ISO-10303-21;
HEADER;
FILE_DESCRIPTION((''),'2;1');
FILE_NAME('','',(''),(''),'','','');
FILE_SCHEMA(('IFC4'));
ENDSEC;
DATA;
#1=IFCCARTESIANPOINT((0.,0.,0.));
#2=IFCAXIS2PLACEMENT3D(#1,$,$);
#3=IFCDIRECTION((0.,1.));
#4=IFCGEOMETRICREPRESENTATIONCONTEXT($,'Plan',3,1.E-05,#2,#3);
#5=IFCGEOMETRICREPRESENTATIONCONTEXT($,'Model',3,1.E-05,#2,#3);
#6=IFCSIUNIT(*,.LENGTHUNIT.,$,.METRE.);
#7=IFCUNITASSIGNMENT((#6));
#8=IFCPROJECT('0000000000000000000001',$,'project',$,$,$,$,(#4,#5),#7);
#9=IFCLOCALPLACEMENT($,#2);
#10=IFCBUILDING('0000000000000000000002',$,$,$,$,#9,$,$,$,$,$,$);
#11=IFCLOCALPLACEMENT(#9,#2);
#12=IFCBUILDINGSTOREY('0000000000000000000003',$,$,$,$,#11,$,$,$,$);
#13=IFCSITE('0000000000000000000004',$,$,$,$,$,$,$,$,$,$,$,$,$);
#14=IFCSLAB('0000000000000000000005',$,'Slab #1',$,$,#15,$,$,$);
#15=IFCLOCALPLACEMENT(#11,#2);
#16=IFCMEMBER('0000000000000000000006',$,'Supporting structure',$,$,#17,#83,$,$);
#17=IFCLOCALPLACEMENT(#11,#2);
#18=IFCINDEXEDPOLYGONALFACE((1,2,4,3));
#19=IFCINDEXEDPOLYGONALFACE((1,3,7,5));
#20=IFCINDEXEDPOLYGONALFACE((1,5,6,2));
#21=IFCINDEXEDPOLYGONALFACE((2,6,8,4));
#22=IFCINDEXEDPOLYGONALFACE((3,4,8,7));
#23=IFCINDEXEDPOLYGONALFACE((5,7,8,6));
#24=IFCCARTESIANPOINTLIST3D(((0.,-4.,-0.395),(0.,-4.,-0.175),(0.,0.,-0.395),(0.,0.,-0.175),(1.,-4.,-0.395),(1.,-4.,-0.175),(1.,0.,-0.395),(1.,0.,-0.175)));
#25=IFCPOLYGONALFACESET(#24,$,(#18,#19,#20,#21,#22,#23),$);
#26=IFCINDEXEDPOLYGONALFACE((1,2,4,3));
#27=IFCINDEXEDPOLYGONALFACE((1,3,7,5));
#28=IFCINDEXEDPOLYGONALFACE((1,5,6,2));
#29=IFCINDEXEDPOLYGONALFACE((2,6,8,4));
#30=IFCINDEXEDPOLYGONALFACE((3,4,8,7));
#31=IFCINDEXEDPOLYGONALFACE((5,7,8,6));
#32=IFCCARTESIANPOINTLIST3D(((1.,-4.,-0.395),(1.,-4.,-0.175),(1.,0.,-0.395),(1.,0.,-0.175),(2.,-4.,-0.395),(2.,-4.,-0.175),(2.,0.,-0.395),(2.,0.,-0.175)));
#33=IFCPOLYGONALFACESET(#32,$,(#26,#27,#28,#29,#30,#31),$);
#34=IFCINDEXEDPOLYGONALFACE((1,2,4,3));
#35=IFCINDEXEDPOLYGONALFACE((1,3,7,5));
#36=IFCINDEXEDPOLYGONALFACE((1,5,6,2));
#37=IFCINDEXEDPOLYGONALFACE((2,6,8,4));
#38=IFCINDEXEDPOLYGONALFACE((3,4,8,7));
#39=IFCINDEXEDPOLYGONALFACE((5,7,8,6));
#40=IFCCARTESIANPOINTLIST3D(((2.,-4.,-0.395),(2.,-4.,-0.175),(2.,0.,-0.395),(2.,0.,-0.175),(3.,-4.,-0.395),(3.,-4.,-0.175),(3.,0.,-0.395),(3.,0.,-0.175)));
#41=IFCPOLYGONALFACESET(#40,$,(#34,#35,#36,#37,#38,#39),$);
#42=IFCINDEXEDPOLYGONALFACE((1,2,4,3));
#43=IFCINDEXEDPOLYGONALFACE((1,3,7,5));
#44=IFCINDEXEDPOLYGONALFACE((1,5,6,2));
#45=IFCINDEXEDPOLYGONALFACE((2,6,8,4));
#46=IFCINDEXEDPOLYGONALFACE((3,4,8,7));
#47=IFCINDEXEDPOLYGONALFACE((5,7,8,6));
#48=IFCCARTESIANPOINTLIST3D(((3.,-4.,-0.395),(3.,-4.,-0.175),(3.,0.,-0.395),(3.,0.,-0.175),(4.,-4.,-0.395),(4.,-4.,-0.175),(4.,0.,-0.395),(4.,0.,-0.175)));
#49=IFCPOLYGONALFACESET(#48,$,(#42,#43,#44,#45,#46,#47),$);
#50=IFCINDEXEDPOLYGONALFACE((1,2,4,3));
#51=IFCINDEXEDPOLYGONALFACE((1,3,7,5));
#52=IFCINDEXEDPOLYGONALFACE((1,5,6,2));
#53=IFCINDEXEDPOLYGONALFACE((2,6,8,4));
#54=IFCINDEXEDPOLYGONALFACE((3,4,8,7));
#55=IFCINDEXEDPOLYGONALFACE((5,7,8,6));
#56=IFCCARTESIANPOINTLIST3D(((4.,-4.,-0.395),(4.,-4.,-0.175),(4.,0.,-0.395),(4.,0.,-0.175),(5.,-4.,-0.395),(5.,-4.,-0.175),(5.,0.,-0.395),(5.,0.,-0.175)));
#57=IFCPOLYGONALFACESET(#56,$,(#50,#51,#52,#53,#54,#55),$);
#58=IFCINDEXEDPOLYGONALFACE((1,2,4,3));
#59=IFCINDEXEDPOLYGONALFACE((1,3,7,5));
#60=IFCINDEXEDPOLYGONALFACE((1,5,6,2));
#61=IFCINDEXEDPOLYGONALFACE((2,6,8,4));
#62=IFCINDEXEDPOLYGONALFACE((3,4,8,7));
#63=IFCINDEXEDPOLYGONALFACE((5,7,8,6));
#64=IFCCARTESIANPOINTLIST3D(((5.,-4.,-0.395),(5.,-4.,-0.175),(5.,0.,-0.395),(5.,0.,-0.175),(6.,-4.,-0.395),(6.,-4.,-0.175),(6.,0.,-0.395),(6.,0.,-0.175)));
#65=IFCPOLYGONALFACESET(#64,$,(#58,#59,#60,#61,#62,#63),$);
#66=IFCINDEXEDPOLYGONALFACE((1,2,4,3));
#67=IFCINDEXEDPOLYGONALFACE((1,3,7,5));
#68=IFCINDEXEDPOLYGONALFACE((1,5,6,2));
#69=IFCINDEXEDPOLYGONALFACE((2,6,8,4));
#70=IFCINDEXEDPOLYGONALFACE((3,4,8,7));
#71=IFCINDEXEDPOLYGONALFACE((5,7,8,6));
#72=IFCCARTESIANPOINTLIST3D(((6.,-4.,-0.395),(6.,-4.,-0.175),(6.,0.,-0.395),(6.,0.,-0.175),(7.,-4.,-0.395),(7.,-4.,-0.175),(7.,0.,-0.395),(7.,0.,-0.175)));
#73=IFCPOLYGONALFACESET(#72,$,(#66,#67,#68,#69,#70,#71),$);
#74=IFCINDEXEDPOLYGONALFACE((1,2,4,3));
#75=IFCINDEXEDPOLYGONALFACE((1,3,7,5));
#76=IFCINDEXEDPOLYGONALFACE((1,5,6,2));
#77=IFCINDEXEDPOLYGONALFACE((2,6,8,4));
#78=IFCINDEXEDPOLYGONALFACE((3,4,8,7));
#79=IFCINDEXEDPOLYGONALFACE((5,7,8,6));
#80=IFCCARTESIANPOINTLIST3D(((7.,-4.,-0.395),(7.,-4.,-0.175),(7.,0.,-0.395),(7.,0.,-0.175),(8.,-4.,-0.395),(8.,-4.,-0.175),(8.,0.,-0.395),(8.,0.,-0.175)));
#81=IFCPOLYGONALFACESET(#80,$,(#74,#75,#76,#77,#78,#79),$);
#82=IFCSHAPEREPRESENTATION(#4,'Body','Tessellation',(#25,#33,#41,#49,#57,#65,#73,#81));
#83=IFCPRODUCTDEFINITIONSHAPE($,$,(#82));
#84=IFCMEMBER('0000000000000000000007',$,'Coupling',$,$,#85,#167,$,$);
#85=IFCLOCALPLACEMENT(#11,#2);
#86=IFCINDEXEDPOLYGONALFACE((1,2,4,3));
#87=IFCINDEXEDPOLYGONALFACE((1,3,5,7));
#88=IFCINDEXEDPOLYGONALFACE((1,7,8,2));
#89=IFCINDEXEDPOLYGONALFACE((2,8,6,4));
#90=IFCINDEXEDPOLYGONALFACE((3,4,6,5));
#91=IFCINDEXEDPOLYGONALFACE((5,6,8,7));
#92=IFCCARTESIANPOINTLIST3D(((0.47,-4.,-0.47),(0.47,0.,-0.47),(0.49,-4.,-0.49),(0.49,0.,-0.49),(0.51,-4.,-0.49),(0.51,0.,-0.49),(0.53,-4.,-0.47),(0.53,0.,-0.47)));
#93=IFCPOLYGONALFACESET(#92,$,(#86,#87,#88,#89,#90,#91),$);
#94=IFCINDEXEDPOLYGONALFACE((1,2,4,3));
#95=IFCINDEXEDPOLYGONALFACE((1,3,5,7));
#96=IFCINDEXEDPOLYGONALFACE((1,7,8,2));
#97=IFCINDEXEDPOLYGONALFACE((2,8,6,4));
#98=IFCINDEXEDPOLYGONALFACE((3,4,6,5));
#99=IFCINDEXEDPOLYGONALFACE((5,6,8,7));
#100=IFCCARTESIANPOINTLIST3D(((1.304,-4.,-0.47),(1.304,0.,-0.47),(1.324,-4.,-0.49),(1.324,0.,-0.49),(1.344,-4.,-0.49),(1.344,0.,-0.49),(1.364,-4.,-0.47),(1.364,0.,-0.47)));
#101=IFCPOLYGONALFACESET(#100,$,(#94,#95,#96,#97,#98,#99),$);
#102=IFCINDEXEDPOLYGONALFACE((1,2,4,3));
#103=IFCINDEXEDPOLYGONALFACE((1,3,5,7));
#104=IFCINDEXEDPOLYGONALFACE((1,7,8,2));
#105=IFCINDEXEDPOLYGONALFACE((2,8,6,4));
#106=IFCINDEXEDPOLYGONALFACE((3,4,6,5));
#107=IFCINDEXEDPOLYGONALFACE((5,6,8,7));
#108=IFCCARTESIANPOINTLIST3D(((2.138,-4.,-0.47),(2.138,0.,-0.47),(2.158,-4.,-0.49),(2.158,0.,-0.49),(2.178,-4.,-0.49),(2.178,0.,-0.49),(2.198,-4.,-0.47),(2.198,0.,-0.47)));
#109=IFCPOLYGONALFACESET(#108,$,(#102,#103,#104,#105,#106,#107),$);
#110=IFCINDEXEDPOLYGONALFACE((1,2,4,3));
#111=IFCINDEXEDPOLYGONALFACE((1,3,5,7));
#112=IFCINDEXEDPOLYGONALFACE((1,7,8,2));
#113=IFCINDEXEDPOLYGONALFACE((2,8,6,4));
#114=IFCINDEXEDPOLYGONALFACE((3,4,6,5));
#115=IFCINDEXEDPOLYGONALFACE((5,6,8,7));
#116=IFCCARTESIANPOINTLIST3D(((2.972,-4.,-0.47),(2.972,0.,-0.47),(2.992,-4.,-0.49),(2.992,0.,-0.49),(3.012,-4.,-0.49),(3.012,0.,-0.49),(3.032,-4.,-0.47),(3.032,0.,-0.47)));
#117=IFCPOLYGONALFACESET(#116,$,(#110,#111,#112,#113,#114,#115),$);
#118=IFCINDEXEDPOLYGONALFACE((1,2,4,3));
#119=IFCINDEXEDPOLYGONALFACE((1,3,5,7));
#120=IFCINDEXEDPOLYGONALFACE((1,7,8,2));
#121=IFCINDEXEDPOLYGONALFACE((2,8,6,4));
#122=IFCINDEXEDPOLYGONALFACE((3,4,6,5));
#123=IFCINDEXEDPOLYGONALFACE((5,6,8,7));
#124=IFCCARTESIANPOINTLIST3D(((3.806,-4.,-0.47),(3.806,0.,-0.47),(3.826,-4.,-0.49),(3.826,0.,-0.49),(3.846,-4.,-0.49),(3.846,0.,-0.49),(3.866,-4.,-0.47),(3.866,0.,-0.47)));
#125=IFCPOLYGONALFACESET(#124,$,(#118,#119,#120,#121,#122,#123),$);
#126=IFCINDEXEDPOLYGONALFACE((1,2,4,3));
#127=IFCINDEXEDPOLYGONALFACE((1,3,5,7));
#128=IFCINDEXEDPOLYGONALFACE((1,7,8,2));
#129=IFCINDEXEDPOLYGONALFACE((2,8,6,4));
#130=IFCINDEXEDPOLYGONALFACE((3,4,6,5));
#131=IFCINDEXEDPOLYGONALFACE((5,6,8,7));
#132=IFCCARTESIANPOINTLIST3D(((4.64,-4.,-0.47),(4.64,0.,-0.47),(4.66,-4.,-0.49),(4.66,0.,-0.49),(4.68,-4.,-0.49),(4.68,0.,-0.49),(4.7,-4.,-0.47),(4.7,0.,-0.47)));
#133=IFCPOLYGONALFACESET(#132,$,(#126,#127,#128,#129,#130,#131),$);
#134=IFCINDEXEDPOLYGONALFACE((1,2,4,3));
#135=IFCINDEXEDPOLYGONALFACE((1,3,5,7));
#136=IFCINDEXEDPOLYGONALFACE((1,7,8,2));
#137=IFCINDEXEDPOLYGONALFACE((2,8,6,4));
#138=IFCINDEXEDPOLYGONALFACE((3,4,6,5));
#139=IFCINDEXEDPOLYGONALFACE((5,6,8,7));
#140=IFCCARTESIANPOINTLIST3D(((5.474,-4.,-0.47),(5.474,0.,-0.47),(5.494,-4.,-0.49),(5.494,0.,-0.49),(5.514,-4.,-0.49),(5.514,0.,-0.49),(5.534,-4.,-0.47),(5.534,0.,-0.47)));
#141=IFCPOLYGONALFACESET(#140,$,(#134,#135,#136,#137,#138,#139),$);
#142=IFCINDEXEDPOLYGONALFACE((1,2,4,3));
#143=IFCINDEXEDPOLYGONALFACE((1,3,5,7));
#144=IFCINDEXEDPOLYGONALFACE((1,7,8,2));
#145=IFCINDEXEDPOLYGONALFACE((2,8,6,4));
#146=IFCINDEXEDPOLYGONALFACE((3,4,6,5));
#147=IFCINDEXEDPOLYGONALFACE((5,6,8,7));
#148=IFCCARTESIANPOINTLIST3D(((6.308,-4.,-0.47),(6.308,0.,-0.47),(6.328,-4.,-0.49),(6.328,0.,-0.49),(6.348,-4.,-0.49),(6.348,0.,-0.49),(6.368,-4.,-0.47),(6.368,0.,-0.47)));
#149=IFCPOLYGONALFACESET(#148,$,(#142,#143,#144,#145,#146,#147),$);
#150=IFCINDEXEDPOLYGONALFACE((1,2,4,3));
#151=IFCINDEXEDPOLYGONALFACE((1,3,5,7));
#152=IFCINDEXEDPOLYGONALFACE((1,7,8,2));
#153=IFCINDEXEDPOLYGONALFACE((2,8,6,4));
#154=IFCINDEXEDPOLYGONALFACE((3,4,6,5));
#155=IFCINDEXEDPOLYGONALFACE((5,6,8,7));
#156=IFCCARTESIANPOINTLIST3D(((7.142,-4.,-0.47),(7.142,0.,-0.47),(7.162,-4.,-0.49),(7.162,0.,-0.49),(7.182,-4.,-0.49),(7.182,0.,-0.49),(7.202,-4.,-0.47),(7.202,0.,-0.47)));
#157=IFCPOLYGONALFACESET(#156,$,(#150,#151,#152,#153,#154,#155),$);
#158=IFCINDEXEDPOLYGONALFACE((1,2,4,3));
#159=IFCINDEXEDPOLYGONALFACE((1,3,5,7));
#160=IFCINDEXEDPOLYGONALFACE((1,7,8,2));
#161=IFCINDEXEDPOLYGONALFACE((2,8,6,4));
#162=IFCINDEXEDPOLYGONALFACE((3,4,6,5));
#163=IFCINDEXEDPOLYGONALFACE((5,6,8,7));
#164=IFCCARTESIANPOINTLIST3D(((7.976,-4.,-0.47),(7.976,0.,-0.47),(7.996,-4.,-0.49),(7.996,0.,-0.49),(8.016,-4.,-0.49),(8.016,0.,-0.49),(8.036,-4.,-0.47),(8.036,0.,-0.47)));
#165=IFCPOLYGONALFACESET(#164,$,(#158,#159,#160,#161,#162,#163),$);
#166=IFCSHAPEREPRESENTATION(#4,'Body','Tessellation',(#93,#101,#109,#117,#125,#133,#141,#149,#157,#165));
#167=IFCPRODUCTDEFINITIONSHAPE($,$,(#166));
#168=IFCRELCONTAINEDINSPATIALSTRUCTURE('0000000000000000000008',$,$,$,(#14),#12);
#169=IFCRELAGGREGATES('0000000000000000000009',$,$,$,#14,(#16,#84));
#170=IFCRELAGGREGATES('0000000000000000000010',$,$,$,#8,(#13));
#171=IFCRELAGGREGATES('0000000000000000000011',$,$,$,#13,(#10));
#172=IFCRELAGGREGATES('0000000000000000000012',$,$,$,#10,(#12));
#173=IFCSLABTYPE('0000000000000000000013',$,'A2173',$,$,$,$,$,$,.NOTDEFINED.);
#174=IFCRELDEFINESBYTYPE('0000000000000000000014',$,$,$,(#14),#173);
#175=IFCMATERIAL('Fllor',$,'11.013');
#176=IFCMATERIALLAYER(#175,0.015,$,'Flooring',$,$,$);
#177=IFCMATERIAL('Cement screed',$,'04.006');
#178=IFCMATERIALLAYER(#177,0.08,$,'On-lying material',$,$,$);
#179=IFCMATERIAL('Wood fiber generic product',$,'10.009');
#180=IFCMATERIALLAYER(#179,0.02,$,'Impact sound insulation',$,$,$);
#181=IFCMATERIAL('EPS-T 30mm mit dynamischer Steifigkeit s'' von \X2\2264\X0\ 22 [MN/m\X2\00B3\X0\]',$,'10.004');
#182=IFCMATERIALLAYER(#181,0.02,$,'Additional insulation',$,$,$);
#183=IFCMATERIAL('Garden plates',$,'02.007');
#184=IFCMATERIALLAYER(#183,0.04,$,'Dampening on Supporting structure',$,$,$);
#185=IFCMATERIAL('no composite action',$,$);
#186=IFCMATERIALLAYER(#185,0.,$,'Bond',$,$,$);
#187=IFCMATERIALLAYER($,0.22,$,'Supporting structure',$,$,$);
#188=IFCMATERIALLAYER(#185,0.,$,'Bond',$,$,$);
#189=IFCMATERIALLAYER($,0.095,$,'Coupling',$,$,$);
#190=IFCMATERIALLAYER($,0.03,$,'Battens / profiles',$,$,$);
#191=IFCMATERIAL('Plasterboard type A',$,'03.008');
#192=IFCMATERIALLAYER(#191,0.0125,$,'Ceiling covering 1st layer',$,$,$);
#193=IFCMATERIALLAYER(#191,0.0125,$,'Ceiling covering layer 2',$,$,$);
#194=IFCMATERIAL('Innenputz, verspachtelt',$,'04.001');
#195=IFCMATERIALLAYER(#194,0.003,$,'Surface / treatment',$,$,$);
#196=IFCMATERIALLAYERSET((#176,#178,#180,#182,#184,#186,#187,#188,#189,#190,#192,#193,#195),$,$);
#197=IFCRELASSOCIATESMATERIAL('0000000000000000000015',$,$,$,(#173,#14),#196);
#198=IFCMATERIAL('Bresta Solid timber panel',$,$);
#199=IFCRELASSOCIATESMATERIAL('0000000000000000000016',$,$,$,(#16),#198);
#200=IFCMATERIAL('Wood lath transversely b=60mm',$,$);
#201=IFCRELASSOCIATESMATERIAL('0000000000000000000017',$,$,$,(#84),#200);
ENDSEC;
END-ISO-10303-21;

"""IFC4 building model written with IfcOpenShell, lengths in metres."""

from ifc_helpers import new_model, si_unit, direction, frame, frame_2d, origin, place, context, project, spatial, polyline, rectangle, outline, extrude, material, layer, layer_set, type_object, element, aggregate, save


model = new_model("IFC4")

# Units and contexts
plan_context = context("Plan", 3, precision=1e-05, world=origin(), true_north=direction((0.0, 1.0)))
model_context = context("Model", 3, precision=1e-05, world=origin(), true_north=direction((0.0, 1.0)))
ifc_project = project(units=[si_unit("LENGTHUNIT", "METRE")], contexts=[plan_context, model_context])

# Site, building, storey
site = spatial("IfcSite", under=ifc_project)
building_placement = place(None, origin())
building = spatial("IfcBuilding", under=site, at=building_placement)
storey_placement = place(building_placement, origin())
storey = spatial("IfcBuildingStorey", under=building, at=storey_placement)

# Slab, members
ifc_material_1 = material(Name="Fllor", Category="11.013")
ifc_layer_1 = layer(ifc_material_1, 0.015, Name="Flooring")
ifc_material_2 = material(Name="Cement screed", Category="04.006")
ifc_layer_2 = layer(ifc_material_2, 0.08, Name="On-lying material")
ifc_material_3 = material(Name="Wood fiber generic product", Category="10.009")
ifc_layer_3 = layer(ifc_material_3, 0.02, Name="Impact sound insulation")
ifc_material_4 = material(Name="EPS-T 30mm mit dynamischer Steifigkeit s' von ≤ 22 [MN/m³]", Category="10.004")
ifc_layer_4 = layer(ifc_material_4, 0.02, Name="Additional insulation")
ifc_material_5 = material(Name="Garden plates", Category="02.007")
ifc_layer_5 = layer(ifc_material_5, 0.04, Name="Dampening on Supporting structure")
ifc_material_6 = material(Name="no composite action")
ifc_layer_6 = layer(ifc_material_6, 0.0, Name="Bond")
ifc_layer_7 = layer(None, 0.22, Name="Supporting structure")
ifc_layer_8 = layer(ifc_material_6, 0.0, Name="Bond")
ifc_layer_9 = layer(None, 0.095, Name="Coupling")
ifc_layer_10 = layer(None, 0.03, Name="Battens / profiles")
ifc_material_7 = material(Name="Plasterboard type A", Category="03.008")
ifc_layer_11 = layer(ifc_material_7, 0.0125, Name="Ceiling covering 1st layer")
ifc_layer_12 = layer(ifc_material_7, 0.0125, Name="Ceiling covering layer 2")
ifc_material_8 = material(Name="Innenputz, verspachtelt", Category="04.001")
ifc_layer_13 = layer(ifc_material_8, 0.003, Name="Surface / treatment")
ifc_layer_set = layer_set([ifc_layer_1, ifc_layer_2, ifc_layer_3, ifc_layer_4, ifc_layer_5, ifc_layer_6, ifc_layer_7, ifc_layer_8, ifc_layer_9, ifc_layer_10, ifc_layer_11, ifc_layer_12, ifc_layer_13])
slab_type = type_object("IfcSlabType", Name="A2173", PredefinedType="NOTDEFINED", material=ifc_layer_set)
slab_placement = place(None, frame((0.0, 0.0, 0.0), z_axis=(0.0, 0.0, -1.0), x_axis=(1.0, 0.0, 0.0)))
slab = element("IfcSlab", 1, at=slab_placement, inside=storey, type_object=slab_type, material=ifc_layer_set, Name="Slab #1")
ifc_material_9 = material(Name="Bresta Solid timber panel")
member_1_placement = place(slab_placement, origin())
member_1 = element("IfcMember", 2, at=member_1_placement, material=ifc_material_9, Name="Supporting structure", context=plan_context, shape_type="SweptSolid", body=[
    extrude(rectangle(XDim=1.0, YDim=0.22, at=frame_2d((0.5, 0.11), x_axis=(1.0, 0.0))), frame((0.0, 4.0, 0.175), z_axis=(0.0, -1.0, 0.0), x_axis=(1.0, 0.0, 0.0)), (0.0, 0.0, 1.0), 4.0),
    extrude(rectangle(XDim=1.0, YDim=0.22, at=frame_2d((0.5, 0.11), x_axis=(1.0, 0.0))), frame((1.0, 4.0, 0.175), z_axis=(0.0, -1.0, 0.0), x_axis=(1.0, 0.0, 0.0)), (0.0, 0.0, 1.0), 4.0),
    extrude(rectangle(XDim=1.0, YDim=0.22, at=frame_2d((0.5, 0.11), x_axis=(1.0, 0.0))), frame((2.0, 4.0, 0.175), z_axis=(0.0, -1.0, 0.0), x_axis=(1.0, 0.0, 0.0)), (0.0, 0.0, 1.0), 4.0),
    extrude(rectangle(XDim=1.0, YDim=0.22, at=frame_2d((0.5, 0.11), x_axis=(1.0, 0.0))), frame((3.0, 4.0, 0.175), z_axis=(0.0, -1.0, 0.0), x_axis=(1.0, 0.0, 0.0)), (0.0, 0.0, 1.0), 4.0),
    extrude(rectangle(XDim=1.0, YDim=0.22, at=frame_2d((0.5, 0.11), x_axis=(1.0, 0.0))), frame((4.0, 4.0, 0.175), z_axis=(0.0, -1.0, 0.0), x_axis=(1.0, 0.0, 0.0)), (0.0, 0.0, 1.0), 4.0),
    extrude(rectangle(XDim=1.0, YDim=0.22, at=frame_2d((0.5, 0.11), x_axis=(1.0, 0.0))), frame((5.0, 4.0, 0.175), z_axis=(0.0, -1.0, 0.0), x_axis=(1.0, 0.0, 0.0)), (0.0, 0.0, 1.0), 4.0),
    extrude(rectangle(XDim=1.0, YDim=0.22, at=frame_2d((0.5, 0.11), x_axis=(1.0, 0.0))), frame((6.0, 4.0, 0.175), z_axis=(0.0, -1.0, 0.0), x_axis=(1.0, 0.0, 0.0)), (0.0, 0.0, 1.0), 4.0),
    extrude(rectangle(XDim=1.0, YDim=0.22, at=frame_2d((0.5, 0.11), x_axis=(1.0, 0.0))), frame((7.0, 4.0, 0.175), z_axis=(0.0, -1.0, 0.0), x_axis=(1.0, 0.0, 0.0)), (0.0, 0.0, 1.0), 4.0),
])
ifc_material_10 = material(Name="Wood lath transversely b=60mm")
member_2_placement = place(slab_placement, origin())
member_2 = element("IfcMember", 3, at=member_2_placement, material=ifc_material_10, Name="Coupling", context=plan_context, shape_type="SweptSolid", body=[
    extrude(outline(polyline([(0.0, 0.0), (0.06, 0.0), (0.04, 0.02), (0.02, 0.02), (0.0, 0.0)])), frame((0.47, 4.0, 0.47), z_axis=(0.0, -1.0, 0.0), x_axis=(1.0, 0.0, 0.0)), (0.0, 0.0, 1.0), 4.0),
    extrude(outline(polyline([(0.0, 0.0), (0.06, 0.0), (0.04, 0.02), (0.02, 0.02), (0.0, 0.0)])), frame((1.304, 4.0, 0.47), z_axis=(0.0, -1.0, 0.0), x_axis=(1.0, 0.0, 0.0)), (0.0, 0.0, 1.0), 4.0),
    extrude(outline(polyline([(0.0, 0.0), (0.06, 0.0), (0.04, 0.02), (0.02, 0.02), (0.0, 0.0)])), frame((2.138, 4.0, 0.47), z_axis=(0.0, -1.0, 0.0), x_axis=(1.0, 0.0, 0.0)), (0.0, 0.0, 1.0), 4.0),
    extrude(outline(polyline([(0.0, 0.0), (0.06, 0.0), (0.04, 0.02), (0.02, 0.02), (0.0, 0.0)])), frame((2.972, 4.0, 0.47), z_axis=(0.0, -1.0, 0.0), x_axis=(1.0, 0.0, 0.0)), (0.0, 0.0, 1.0), 4.0),
    extrude(outline(polyline([(0.0, 0.0), (0.06, 0.0), (0.04, 0.02), (0.02, 0.02), (0.0, 0.0)])), frame((3.806, 4.0, 0.47), z_axis=(0.0, -1.0, 0.0), x_axis=(1.0, 0.0, 0.0)), (0.0, 0.0, 1.0), 4.0),
    extrude(outline(polyline([(0.0, 0.0), (0.06, 0.0), (0.04, 0.02), (0.02, 0.02), (0.0, 0.0)])), frame((4.64, 4.0, 0.47), z_axis=(0.0, -1.0, 0.0), x_axis=(1.0, 0.0, 0.0)), (0.0, 0.0, 1.0), 4.0),
    extrude(outline(polyline([(0.0, 0.0), (0.06, 0.0), (0.04, 0.02), (0.02, 0.02), (0.0, 0.0)])), frame((5.474, 4.0, 0.47), z_axis=(0.0, -1.0, 0.0), x_axis=(1.0, 0.0, 0.0)), (0.0, 0.0, 1.0), 4.0),
    extrude(outline(polyline([(0.0, 0.0), (0.06, 0.0), (0.04, 0.02), (0.02, 0.02), (0.0, 0.0)])), frame((6.308, 4.0, 0.47), z_axis=(0.0, -1.0, 0.0), x_axis=(1.0, 0.0, 0.0)), (0.0, 0.0, 1.0), 4.0),
    extrude(outline(polyline([(0.0, 0.0), (0.06, 0.0), (0.04, 0.02), (0.02, 0.02), (0.0, 0.0)])), frame((7.142, 4.0, 0.47), z_axis=(0.0, -1.0, 0.0), x_axis=(1.0, 0.0, 0.0)), (0.0, 0.0, 1.0), 4.0),
    extrude(outline(polyline([(0.0, 0.0), (0.06, 0.0), (0.04, 0.02), (0.02, 0.02), (0.0, 0.0)])), frame((7.976, 4.0, 0.47), z_axis=(0.0, -1.0, 0.0), x_axis=(1.0, 0.0, 0.0)), (0.0, 0.0, 1.0), 4.0),
])
aggregate(slab, [member_1, member_2])

save(model, "model.ifc")
